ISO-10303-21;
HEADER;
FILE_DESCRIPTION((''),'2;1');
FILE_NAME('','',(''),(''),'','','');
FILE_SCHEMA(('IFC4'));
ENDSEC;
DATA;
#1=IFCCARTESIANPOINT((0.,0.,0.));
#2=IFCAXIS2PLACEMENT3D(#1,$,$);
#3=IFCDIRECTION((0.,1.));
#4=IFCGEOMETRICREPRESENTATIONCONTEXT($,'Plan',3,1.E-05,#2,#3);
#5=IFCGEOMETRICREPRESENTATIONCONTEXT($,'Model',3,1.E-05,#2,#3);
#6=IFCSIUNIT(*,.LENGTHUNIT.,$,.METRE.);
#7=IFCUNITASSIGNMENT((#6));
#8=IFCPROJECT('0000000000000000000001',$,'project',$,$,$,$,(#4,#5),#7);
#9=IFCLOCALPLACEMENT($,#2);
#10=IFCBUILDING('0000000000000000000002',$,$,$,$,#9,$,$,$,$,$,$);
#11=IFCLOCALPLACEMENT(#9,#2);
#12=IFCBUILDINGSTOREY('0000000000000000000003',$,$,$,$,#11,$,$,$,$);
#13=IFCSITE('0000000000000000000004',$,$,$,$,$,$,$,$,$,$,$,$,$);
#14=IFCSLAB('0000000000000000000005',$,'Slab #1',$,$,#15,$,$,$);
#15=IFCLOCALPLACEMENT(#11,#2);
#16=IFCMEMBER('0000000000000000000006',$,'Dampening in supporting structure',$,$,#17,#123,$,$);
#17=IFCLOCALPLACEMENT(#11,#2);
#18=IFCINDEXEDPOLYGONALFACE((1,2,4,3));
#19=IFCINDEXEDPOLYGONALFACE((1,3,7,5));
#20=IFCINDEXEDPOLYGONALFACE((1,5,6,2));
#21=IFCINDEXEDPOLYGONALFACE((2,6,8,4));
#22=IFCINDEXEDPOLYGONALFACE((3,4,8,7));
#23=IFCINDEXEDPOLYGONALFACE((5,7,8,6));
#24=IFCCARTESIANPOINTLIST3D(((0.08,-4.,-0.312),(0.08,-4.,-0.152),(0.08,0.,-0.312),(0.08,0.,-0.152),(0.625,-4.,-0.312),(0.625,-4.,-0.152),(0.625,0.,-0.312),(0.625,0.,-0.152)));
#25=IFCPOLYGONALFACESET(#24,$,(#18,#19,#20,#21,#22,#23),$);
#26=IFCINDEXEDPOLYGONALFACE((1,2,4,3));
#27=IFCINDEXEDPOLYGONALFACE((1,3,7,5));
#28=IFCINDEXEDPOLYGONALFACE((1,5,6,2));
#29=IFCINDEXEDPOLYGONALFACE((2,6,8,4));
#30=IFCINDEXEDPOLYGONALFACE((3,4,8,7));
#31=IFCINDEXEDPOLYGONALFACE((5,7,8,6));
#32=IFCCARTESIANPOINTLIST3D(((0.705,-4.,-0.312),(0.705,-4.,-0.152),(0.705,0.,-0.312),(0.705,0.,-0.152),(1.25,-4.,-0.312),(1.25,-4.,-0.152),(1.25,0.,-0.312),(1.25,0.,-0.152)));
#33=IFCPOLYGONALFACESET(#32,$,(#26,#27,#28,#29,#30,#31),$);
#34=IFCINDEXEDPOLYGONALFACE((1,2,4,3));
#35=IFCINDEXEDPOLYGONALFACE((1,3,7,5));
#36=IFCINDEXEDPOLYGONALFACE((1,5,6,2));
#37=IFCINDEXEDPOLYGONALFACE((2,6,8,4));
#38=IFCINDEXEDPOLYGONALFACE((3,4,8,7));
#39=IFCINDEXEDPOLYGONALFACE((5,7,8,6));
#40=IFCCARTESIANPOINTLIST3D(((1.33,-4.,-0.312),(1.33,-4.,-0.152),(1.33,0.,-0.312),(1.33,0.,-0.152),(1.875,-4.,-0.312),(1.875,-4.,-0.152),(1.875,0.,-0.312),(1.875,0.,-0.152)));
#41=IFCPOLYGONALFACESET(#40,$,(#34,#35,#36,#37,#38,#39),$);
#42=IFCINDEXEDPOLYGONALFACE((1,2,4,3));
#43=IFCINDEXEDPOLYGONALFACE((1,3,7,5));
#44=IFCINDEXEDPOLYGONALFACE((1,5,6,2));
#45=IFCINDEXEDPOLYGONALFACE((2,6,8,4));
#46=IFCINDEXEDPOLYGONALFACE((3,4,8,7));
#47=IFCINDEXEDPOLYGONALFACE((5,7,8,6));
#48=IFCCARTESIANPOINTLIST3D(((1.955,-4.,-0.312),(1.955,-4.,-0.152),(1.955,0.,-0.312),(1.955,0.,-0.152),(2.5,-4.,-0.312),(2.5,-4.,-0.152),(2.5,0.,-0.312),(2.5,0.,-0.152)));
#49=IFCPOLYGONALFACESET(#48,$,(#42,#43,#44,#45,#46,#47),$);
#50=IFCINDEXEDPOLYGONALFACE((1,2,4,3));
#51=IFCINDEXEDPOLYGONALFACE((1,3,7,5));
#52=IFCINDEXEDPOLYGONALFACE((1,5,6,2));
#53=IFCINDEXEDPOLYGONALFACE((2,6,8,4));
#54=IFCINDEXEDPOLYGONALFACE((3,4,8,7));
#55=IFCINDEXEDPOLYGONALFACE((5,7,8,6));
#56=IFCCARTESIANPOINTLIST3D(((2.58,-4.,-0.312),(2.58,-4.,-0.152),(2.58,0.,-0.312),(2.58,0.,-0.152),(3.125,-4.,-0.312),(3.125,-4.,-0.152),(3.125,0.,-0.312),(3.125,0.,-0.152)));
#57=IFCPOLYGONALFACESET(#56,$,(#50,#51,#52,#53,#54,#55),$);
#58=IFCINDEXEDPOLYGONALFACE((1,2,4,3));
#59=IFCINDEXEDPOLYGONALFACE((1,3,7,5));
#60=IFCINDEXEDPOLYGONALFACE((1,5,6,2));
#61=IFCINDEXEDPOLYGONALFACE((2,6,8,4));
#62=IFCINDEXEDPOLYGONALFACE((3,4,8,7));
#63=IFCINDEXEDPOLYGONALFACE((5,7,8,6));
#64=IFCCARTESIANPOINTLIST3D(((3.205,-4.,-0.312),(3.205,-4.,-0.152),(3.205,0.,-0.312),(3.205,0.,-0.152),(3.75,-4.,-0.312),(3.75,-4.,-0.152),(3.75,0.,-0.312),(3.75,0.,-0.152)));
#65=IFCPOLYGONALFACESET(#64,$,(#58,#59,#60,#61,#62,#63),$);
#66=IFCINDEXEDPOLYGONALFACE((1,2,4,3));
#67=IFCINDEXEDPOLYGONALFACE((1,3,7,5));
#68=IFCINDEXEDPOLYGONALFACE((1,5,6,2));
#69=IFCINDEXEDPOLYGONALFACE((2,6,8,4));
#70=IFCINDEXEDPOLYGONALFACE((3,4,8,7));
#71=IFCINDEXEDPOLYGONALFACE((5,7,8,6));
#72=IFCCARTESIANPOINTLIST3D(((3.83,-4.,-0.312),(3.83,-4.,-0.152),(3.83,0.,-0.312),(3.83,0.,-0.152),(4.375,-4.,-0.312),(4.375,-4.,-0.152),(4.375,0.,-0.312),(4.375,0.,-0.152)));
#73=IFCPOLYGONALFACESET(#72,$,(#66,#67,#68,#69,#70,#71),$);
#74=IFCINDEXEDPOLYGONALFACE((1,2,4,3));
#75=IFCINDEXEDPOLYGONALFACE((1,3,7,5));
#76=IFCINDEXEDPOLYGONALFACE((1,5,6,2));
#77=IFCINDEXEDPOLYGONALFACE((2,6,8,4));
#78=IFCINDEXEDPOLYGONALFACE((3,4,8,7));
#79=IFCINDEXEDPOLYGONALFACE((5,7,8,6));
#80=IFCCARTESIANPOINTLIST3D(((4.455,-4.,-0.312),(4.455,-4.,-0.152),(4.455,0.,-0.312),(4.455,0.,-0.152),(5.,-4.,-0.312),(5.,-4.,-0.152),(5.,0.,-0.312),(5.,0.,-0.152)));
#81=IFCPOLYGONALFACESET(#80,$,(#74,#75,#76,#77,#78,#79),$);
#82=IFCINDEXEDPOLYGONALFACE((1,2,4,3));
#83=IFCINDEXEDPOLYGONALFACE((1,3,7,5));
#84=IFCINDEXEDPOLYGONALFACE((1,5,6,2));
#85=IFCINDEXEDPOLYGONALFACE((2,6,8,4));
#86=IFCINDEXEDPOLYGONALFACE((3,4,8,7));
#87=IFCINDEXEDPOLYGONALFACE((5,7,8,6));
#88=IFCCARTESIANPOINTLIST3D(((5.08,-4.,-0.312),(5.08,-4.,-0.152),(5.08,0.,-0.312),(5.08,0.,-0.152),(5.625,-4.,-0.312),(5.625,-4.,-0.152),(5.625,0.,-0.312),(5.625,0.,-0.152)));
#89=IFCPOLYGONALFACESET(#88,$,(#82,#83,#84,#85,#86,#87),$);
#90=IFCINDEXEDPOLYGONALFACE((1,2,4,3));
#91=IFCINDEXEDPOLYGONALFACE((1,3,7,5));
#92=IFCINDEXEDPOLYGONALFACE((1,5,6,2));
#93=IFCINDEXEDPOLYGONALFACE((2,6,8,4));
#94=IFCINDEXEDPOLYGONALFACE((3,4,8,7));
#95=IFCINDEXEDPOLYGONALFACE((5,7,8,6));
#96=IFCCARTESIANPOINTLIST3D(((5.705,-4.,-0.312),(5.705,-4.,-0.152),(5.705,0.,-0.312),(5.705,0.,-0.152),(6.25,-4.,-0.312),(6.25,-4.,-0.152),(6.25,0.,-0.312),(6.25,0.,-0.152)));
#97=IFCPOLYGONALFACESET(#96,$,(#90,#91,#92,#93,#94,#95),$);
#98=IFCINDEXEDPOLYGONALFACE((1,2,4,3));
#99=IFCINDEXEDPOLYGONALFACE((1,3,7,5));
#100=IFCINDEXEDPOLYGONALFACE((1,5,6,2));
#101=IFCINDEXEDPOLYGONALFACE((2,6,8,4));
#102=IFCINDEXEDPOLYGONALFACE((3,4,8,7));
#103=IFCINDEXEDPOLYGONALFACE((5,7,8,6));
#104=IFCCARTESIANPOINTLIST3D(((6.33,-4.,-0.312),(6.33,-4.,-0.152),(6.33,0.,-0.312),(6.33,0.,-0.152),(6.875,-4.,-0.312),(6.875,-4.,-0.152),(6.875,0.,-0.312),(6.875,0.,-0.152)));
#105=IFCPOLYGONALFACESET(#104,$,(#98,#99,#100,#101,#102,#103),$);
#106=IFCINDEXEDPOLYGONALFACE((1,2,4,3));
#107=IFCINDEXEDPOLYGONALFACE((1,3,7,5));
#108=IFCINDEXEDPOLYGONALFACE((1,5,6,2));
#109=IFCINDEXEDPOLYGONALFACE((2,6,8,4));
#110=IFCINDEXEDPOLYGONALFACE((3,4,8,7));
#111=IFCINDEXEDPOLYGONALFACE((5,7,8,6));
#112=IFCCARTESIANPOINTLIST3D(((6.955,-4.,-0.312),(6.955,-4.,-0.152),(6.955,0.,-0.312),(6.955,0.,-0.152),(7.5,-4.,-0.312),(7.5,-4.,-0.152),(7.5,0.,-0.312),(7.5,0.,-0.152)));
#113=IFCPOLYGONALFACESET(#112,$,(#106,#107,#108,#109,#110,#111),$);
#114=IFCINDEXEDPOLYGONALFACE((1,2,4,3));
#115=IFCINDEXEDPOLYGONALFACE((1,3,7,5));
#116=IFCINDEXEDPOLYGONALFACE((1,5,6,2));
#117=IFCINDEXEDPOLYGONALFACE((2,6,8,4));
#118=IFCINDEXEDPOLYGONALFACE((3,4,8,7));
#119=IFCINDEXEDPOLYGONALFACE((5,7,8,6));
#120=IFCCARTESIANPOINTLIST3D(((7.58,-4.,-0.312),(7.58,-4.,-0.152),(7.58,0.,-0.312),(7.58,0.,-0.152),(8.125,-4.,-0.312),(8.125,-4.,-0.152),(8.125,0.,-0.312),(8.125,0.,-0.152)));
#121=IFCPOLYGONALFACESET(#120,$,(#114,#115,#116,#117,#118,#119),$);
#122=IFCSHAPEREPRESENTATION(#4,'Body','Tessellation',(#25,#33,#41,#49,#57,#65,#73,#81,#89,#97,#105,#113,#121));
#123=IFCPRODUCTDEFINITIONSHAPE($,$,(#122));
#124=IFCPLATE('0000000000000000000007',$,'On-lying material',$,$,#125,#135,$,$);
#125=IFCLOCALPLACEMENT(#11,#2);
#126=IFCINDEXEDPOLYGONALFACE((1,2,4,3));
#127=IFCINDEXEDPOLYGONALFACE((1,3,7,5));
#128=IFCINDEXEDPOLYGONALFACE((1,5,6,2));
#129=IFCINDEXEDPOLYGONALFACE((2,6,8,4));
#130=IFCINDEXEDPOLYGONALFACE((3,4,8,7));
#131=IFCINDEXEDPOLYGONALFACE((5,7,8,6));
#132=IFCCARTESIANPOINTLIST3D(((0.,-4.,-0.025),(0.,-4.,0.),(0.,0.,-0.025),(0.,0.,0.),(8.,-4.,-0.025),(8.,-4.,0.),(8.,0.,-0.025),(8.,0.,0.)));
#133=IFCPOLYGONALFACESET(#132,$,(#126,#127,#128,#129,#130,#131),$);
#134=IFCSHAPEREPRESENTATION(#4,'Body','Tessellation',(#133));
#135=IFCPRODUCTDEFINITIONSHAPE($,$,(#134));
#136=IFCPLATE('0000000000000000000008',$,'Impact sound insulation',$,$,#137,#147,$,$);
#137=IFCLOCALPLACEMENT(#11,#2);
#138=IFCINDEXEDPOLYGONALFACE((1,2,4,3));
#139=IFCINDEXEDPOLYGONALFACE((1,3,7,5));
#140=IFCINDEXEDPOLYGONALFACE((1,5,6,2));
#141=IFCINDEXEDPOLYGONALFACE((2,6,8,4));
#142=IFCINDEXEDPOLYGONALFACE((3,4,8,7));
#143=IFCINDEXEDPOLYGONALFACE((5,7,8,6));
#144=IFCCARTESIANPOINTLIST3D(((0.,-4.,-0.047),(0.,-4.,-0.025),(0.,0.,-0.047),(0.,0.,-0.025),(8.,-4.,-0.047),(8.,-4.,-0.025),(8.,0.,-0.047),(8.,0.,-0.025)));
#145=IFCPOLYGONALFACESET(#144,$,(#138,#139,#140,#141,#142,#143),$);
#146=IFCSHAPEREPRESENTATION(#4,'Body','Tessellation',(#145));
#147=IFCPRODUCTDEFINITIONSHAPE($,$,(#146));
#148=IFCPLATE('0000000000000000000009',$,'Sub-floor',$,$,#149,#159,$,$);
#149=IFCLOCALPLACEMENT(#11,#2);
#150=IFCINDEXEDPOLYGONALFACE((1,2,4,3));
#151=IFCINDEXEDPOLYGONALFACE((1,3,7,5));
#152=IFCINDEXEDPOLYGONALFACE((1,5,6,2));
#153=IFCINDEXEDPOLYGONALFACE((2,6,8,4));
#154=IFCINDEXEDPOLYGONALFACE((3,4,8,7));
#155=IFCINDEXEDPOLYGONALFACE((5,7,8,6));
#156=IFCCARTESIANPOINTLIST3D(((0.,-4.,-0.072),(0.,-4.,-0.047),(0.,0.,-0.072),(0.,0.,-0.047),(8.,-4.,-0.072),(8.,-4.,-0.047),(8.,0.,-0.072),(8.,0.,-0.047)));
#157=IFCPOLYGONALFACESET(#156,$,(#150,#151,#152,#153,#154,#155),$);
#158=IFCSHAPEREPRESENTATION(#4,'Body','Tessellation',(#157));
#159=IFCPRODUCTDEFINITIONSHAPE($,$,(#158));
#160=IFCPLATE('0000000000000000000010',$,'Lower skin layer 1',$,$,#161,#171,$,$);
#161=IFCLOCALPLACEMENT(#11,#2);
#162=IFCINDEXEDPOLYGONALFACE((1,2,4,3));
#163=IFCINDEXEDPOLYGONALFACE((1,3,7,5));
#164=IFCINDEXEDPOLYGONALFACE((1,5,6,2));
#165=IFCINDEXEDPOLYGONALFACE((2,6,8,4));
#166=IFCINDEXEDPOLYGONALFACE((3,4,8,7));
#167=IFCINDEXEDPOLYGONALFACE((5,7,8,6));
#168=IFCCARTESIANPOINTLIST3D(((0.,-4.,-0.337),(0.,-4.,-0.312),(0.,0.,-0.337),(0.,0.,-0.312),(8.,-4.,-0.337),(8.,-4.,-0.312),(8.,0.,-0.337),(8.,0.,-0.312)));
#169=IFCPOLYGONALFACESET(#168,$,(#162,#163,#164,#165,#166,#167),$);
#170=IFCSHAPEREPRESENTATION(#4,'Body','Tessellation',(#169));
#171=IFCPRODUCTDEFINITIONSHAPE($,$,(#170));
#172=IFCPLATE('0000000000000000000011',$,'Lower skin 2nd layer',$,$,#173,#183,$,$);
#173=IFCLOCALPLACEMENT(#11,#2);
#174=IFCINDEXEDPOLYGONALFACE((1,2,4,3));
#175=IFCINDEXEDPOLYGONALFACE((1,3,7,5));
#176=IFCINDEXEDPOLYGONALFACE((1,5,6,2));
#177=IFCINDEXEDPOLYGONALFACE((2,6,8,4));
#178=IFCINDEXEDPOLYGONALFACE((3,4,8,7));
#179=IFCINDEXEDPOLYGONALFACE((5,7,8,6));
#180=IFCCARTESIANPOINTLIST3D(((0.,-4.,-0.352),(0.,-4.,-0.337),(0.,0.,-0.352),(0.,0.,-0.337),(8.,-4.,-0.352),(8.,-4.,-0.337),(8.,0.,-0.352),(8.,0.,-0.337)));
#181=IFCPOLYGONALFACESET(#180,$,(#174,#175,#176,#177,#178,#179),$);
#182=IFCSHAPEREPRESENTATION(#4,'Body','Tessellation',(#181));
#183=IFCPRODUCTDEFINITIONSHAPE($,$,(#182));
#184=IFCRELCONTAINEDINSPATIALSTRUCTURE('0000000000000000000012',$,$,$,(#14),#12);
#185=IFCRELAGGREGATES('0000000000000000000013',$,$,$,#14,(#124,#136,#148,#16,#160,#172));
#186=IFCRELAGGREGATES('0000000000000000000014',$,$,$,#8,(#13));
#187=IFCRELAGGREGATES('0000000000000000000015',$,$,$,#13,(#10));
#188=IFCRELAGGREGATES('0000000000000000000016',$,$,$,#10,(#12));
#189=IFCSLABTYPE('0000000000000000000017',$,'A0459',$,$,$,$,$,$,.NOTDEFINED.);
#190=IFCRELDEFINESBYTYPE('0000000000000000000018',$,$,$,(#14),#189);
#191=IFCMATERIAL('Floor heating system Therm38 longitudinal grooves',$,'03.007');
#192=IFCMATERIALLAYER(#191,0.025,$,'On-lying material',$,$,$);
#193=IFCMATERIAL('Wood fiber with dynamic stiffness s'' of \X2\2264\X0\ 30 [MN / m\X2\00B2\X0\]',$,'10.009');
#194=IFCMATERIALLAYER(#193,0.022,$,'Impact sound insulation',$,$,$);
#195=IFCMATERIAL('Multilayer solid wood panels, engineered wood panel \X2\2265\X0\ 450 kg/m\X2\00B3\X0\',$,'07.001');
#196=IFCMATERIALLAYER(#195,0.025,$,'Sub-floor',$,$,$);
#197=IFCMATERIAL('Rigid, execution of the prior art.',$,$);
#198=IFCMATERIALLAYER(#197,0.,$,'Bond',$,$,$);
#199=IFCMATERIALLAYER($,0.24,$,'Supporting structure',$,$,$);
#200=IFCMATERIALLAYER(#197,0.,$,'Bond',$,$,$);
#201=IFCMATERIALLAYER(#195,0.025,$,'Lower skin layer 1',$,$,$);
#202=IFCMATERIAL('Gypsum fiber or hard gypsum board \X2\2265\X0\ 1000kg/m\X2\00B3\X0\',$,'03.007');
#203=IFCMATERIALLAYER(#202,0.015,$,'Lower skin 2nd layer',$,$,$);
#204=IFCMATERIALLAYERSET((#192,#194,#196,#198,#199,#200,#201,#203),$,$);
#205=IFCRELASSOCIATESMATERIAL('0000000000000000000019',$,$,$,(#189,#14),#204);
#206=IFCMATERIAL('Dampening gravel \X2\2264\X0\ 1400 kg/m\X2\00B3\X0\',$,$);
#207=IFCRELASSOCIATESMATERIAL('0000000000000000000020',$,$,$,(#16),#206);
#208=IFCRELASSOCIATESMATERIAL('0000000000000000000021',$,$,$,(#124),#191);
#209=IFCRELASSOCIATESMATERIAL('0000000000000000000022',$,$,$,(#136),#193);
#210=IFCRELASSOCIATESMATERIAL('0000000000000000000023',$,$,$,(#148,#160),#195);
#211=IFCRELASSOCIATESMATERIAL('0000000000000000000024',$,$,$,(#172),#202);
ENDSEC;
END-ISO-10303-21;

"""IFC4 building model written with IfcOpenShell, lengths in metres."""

from ifc_helpers import new_model, si_unit, direction, frame, frame_2d, origin, origin_with_axes, place, context, project, spatial, rectangle, extrude, material, layer, layer_set, type_object, element, aggregate, save


model = new_model("IFC4")

# Units and contexts
plan_context = context("Plan", 3, precision=1e-05, world=origin(), true_north=direction((0.0, 1.0)))
model_context = context("Model", 3, precision=1e-05, world=origin(), true_north=direction((0.0, 1.0)))
ifc_project = project(units=[si_unit("LENGTHUNIT", "METRE")], contexts=[plan_context, model_context])

# Site, building, storey
site = spatial("IfcSite", under=ifc_project)
building_placement = place(None, origin())
building = spatial("IfcBuilding", under=site, at=building_placement)
storey_placement = place(building_placement, origin())
storey = spatial("IfcBuildingStorey", under=building, at=storey_placement)

# Slab, member, plates
ifc_material_1 = material(Name="Floor heating system Therm38 longitudinal grooves", Category="03.007")
ifc_layer_1 = layer(ifc_material_1, 0.025, Name="On-lying material")
ifc_material_2 = material(Name="Wood fiber with dynamic stiffness s' of ≤ 30 [MN / m²]", Category="10.009")
ifc_layer_2 = layer(ifc_material_2, 0.022, Name="Impact sound insulation")
ifc_material_3 = material(Name="Multilayer solid wood panels, engineered wood panel ≥ 450 kg/m³", Category="07.001")
ifc_layer_3 = layer(ifc_material_3, 0.025, Name="Sub-floor")
ifc_material_4 = material(Name="Rigid, execution of the prior art.")
ifc_layer_4 = layer(ifc_material_4, 0.0, Name="Bond")
ifc_layer_5 = layer(None, 0.24, Name="Supporting structure")
ifc_layer_6 = layer(ifc_material_4, 0.0, Name="Bond")
ifc_layer_7 = layer(ifc_material_3, 0.025, Name="Lower skin layer 1")
ifc_material_5 = material(Name="Gypsum fiber or hard gypsum board ≥ 1000kg/m³", Category="03.007")
ifc_layer_8 = layer(ifc_material_5, 0.015, Name="Lower skin 2nd layer")
ifc_layer_set = layer_set([ifc_layer_1, ifc_layer_2, ifc_layer_3, ifc_layer_4, ifc_layer_5, ifc_layer_6, ifc_layer_7, ifc_layer_8])
slab_type = type_object("IfcSlabType", Name="A0459", PredefinedType="NOTDEFINED", material=ifc_layer_set)
slab_placement = place(None, frame((0.0, 0.0, 0.0), z_axis=(0.0, 0.0, -1.0), x_axis=(1.0, 0.0, 0.0)))
slab = element("IfcSlab", 1, at=slab_placement, inside=storey, type_object=slab_type, material=ifc_layer_set, Name="Slab #1")
ifc_material_6 = material(Name="Dampening gravel ≤ 1400 kg/m³")
member_1_placement = place(slab_placement, origin())
member_1 = element("IfcMember", 2, at=member_1_placement, material=ifc_material_6, Name="Dampening in supporting structure", context=plan_context, shape_type="SweptSolid", body=[
    extrude(rectangle(XDim=0.545, YDim=0.16, at=frame_2d((0.2725, 0.08), x_axis=(1.0, 0.0))), frame((0.08, 4.0, 0.152), z_axis=(0.0, -1.0, 0.0), x_axis=(1.0, 0.0, 0.0)), (0.0, 0.0, 1.0), 4.0),
    extrude(rectangle(XDim=0.545, YDim=0.16, at=frame_2d((0.2725, 0.08), x_axis=(1.0, 0.0))), frame((0.705, 4.0, 0.152), z_axis=(0.0, -1.0, 0.0), x_axis=(1.0, 0.0, 0.0)), (0.0, 0.0, 1.0), 4.0),
    extrude(rectangle(XDim=0.545, YDim=0.16, at=frame_2d((0.2725, 0.08), x_axis=(1.0, 0.0))), frame((1.33, 4.0, 0.152), z_axis=(0.0, -1.0, 0.0), x_axis=(1.0, 0.0, 0.0)), (0.0, 0.0, 1.0), 4.0),
    extrude(rectangle(XDim=0.545, YDim=0.16, at=frame_2d((0.2725, 0.08), x_axis=(1.0, 0.0))), frame((1.955, 4.0, 0.152), z_axis=(0.0, -1.0, 0.0), x_axis=(1.0, 0.0, 0.0)), (0.0, 0.0, 1.0), 4.0),
    extrude(rectangle(XDim=0.545, YDim=0.16, at=frame_2d((0.2725, 0.08), x_axis=(1.0, 0.0))), frame((2.58, 4.0, 0.152), z_axis=(0.0, -1.0, 0.0), x_axis=(1.0, 0.0, 0.0)), (0.0, 0.0, 1.0), 4.0),
    extrude(rectangle(XDim=0.545, YDim=0.16, at=frame_2d((0.2725, 0.08), x_axis=(1.0, 0.0))), frame((3.205, 4.0, 0.152), z_axis=(0.0, -1.0, 0.0), x_axis=(1.0, 0.0, 0.0)), (0.0, 0.0, 1.0), 4.0),
    extrude(rectangle(XDim=0.545, YDim=0.16, at=frame_2d((0.2725, 0.08), x_axis=(1.0, 0.0))), frame((3.83, 4.0, 0.152), z_axis=(0.0, -1.0, 0.0), x_axis=(1.0, 0.0, 0.0)), (0.0, 0.0, 1.0), 4.0),
    extrude(rectangle(XDim=0.545, YDim=0.16, at=frame_2d((0.2725, 0.08), x_axis=(1.0, 0.0))), frame((4.455, 4.0, 0.152), z_axis=(0.0, -1.0, 0.0), x_axis=(1.0, 0.0, 0.0)), (0.0, 0.0, 1.0), 4.0),
    extrude(rectangle(XDim=0.545, YDim=0.16, at=frame_2d((0.2725, 0.08), x_axis=(1.0, 0.0))), frame((5.08, 4.0, 0.152), z_axis=(0.0, -1.0, 0.0), x_axis=(1.0, 0.0, 0.0)), (0.0, 0.0, 1.0), 4.0),
    extrude(rectangle(XDim=0.545, YDim=0.16, at=frame_2d((0.2725, 0.08), x_axis=(1.0, 0.0))), frame((5.705, 4.0, 0.152), z_axis=(0.0, -1.0, 0.0), x_axis=(1.0, 0.0, 0.0)), (0.0, 0.0, 1.0), 4.0),
    extrude(rectangle(XDim=0.545, YDim=0.16, at=frame_2d((0.2725, 0.08), x_axis=(1.0, 0.0))), frame((6.33, 4.0, 0.152), z_axis=(0.0, -1.0, 0.0), x_axis=(1.0, 0.0, 0.0)), (0.0, 0.0, 1.0), 4.0),
    extrude(rectangle(XDim=0.545, YDim=0.16, at=frame_2d((0.2725, 0.08), x_axis=(1.0, 0.0))), frame((6.955, 4.0, 0.152), z_axis=(0.0, -1.0, 0.0), x_axis=(1.0, 0.0, 0.0)), (0.0, 0.0, 1.0), 4.0),
    extrude(rectangle(XDim=0.545, YDim=0.16, at=frame_2d((0.2725, 0.08), x_axis=(1.0, 0.0))), frame((7.58, 4.0, 0.152), z_axis=(0.0, -1.0, 0.0), x_axis=(1.0, 0.0, 0.0)), (0.0, 0.0, 1.0), 4.0),
])
plate_1_placement = place(slab_placement, origin())
plate_1 = element("IfcPlate", 3, at=plate_1_placement, material=ifc_material_1, Name="On-lying material", context=plan_context, shape_type="SweptSolid", body=[
    extrude(rectangle(XDim=8.0, YDim=4.0, at=frame_2d((4.0, 2.0), x_axis=(1.0, 0.0))), origin_with_axes(), (0.0, 0.0, 1.0), 0.025),
])
plate_2_placement = place(slab_placement, origin())
plate_2 = element("IfcPlate", 4, at=plate_2_placement, material=ifc_material_2, Name="Impact sound insulation", context=plan_context, shape_type="SweptSolid", body=[
    extrude(rectangle(XDim=8.0, YDim=4.0, at=frame_2d((4.0, 2.0), x_axis=(1.0, 0.0))), frame((0.0, 0.0, 0.025), z_axis=(0.0, 0.0, 1.0), x_axis=(1.0, 0.0, 0.0)), (0.0, 0.0, 1.0), 0.022),
])
plate_3_placement = place(slab_placement, origin())
plate_3 = element("IfcPlate", 5, at=plate_3_placement, material=ifc_material_3, Name="Sub-floor", context=plan_context, shape_type="SweptSolid", body=[
    extrude(rectangle(XDim=8.0, YDim=4.0, at=frame_2d((4.0, 2.0), x_axis=(1.0, 0.0))), frame((0.0, 0.0, 0.047), z_axis=(0.0, 0.0, 1.0), x_axis=(1.0, 0.0, 0.0)), (0.0, 0.0, 1.0), 0.025),
])
plate_4_placement = place(slab_placement, origin())
plate_4 = element("IfcPlate", 6, at=plate_4_placement, material=ifc_material_3, Name="Lower skin layer 1", context=plan_context, shape_type="SweptSolid", body=[
    extrude(rectangle(XDim=8.0, YDim=4.0, at=frame_2d((4.0, 2.0), x_axis=(1.0, 0.0))), frame((0.0, 0.0, 0.312), z_axis=(0.0, 0.0, 1.0), x_axis=(1.0, 0.0, 0.0)), (0.0, 0.0, 1.0), 0.025),
])
plate_5_placement = place(slab_placement, origin())
plate_5 = element("IfcPlate", 7, at=plate_5_placement, material=ifc_material_5, Name="Lower skin 2nd layer", context=plan_context, shape_type="SweptSolid", body=[
    extrude(rectangle(XDim=8.0, YDim=4.0, at=frame_2d((4.0, 2.0), x_axis=(1.0, 0.0))), frame((0.0, 0.0, 0.337), z_axis=(0.0, 0.0, 1.0), x_axis=(1.0, 0.0, 0.0)), (0.0, 0.0, 1.0), 0.015),
])
aggregate(slab, [plate_1, plate_2, plate_3, member_1, plate_4, plate_5])

save(model, "model.ifc")
